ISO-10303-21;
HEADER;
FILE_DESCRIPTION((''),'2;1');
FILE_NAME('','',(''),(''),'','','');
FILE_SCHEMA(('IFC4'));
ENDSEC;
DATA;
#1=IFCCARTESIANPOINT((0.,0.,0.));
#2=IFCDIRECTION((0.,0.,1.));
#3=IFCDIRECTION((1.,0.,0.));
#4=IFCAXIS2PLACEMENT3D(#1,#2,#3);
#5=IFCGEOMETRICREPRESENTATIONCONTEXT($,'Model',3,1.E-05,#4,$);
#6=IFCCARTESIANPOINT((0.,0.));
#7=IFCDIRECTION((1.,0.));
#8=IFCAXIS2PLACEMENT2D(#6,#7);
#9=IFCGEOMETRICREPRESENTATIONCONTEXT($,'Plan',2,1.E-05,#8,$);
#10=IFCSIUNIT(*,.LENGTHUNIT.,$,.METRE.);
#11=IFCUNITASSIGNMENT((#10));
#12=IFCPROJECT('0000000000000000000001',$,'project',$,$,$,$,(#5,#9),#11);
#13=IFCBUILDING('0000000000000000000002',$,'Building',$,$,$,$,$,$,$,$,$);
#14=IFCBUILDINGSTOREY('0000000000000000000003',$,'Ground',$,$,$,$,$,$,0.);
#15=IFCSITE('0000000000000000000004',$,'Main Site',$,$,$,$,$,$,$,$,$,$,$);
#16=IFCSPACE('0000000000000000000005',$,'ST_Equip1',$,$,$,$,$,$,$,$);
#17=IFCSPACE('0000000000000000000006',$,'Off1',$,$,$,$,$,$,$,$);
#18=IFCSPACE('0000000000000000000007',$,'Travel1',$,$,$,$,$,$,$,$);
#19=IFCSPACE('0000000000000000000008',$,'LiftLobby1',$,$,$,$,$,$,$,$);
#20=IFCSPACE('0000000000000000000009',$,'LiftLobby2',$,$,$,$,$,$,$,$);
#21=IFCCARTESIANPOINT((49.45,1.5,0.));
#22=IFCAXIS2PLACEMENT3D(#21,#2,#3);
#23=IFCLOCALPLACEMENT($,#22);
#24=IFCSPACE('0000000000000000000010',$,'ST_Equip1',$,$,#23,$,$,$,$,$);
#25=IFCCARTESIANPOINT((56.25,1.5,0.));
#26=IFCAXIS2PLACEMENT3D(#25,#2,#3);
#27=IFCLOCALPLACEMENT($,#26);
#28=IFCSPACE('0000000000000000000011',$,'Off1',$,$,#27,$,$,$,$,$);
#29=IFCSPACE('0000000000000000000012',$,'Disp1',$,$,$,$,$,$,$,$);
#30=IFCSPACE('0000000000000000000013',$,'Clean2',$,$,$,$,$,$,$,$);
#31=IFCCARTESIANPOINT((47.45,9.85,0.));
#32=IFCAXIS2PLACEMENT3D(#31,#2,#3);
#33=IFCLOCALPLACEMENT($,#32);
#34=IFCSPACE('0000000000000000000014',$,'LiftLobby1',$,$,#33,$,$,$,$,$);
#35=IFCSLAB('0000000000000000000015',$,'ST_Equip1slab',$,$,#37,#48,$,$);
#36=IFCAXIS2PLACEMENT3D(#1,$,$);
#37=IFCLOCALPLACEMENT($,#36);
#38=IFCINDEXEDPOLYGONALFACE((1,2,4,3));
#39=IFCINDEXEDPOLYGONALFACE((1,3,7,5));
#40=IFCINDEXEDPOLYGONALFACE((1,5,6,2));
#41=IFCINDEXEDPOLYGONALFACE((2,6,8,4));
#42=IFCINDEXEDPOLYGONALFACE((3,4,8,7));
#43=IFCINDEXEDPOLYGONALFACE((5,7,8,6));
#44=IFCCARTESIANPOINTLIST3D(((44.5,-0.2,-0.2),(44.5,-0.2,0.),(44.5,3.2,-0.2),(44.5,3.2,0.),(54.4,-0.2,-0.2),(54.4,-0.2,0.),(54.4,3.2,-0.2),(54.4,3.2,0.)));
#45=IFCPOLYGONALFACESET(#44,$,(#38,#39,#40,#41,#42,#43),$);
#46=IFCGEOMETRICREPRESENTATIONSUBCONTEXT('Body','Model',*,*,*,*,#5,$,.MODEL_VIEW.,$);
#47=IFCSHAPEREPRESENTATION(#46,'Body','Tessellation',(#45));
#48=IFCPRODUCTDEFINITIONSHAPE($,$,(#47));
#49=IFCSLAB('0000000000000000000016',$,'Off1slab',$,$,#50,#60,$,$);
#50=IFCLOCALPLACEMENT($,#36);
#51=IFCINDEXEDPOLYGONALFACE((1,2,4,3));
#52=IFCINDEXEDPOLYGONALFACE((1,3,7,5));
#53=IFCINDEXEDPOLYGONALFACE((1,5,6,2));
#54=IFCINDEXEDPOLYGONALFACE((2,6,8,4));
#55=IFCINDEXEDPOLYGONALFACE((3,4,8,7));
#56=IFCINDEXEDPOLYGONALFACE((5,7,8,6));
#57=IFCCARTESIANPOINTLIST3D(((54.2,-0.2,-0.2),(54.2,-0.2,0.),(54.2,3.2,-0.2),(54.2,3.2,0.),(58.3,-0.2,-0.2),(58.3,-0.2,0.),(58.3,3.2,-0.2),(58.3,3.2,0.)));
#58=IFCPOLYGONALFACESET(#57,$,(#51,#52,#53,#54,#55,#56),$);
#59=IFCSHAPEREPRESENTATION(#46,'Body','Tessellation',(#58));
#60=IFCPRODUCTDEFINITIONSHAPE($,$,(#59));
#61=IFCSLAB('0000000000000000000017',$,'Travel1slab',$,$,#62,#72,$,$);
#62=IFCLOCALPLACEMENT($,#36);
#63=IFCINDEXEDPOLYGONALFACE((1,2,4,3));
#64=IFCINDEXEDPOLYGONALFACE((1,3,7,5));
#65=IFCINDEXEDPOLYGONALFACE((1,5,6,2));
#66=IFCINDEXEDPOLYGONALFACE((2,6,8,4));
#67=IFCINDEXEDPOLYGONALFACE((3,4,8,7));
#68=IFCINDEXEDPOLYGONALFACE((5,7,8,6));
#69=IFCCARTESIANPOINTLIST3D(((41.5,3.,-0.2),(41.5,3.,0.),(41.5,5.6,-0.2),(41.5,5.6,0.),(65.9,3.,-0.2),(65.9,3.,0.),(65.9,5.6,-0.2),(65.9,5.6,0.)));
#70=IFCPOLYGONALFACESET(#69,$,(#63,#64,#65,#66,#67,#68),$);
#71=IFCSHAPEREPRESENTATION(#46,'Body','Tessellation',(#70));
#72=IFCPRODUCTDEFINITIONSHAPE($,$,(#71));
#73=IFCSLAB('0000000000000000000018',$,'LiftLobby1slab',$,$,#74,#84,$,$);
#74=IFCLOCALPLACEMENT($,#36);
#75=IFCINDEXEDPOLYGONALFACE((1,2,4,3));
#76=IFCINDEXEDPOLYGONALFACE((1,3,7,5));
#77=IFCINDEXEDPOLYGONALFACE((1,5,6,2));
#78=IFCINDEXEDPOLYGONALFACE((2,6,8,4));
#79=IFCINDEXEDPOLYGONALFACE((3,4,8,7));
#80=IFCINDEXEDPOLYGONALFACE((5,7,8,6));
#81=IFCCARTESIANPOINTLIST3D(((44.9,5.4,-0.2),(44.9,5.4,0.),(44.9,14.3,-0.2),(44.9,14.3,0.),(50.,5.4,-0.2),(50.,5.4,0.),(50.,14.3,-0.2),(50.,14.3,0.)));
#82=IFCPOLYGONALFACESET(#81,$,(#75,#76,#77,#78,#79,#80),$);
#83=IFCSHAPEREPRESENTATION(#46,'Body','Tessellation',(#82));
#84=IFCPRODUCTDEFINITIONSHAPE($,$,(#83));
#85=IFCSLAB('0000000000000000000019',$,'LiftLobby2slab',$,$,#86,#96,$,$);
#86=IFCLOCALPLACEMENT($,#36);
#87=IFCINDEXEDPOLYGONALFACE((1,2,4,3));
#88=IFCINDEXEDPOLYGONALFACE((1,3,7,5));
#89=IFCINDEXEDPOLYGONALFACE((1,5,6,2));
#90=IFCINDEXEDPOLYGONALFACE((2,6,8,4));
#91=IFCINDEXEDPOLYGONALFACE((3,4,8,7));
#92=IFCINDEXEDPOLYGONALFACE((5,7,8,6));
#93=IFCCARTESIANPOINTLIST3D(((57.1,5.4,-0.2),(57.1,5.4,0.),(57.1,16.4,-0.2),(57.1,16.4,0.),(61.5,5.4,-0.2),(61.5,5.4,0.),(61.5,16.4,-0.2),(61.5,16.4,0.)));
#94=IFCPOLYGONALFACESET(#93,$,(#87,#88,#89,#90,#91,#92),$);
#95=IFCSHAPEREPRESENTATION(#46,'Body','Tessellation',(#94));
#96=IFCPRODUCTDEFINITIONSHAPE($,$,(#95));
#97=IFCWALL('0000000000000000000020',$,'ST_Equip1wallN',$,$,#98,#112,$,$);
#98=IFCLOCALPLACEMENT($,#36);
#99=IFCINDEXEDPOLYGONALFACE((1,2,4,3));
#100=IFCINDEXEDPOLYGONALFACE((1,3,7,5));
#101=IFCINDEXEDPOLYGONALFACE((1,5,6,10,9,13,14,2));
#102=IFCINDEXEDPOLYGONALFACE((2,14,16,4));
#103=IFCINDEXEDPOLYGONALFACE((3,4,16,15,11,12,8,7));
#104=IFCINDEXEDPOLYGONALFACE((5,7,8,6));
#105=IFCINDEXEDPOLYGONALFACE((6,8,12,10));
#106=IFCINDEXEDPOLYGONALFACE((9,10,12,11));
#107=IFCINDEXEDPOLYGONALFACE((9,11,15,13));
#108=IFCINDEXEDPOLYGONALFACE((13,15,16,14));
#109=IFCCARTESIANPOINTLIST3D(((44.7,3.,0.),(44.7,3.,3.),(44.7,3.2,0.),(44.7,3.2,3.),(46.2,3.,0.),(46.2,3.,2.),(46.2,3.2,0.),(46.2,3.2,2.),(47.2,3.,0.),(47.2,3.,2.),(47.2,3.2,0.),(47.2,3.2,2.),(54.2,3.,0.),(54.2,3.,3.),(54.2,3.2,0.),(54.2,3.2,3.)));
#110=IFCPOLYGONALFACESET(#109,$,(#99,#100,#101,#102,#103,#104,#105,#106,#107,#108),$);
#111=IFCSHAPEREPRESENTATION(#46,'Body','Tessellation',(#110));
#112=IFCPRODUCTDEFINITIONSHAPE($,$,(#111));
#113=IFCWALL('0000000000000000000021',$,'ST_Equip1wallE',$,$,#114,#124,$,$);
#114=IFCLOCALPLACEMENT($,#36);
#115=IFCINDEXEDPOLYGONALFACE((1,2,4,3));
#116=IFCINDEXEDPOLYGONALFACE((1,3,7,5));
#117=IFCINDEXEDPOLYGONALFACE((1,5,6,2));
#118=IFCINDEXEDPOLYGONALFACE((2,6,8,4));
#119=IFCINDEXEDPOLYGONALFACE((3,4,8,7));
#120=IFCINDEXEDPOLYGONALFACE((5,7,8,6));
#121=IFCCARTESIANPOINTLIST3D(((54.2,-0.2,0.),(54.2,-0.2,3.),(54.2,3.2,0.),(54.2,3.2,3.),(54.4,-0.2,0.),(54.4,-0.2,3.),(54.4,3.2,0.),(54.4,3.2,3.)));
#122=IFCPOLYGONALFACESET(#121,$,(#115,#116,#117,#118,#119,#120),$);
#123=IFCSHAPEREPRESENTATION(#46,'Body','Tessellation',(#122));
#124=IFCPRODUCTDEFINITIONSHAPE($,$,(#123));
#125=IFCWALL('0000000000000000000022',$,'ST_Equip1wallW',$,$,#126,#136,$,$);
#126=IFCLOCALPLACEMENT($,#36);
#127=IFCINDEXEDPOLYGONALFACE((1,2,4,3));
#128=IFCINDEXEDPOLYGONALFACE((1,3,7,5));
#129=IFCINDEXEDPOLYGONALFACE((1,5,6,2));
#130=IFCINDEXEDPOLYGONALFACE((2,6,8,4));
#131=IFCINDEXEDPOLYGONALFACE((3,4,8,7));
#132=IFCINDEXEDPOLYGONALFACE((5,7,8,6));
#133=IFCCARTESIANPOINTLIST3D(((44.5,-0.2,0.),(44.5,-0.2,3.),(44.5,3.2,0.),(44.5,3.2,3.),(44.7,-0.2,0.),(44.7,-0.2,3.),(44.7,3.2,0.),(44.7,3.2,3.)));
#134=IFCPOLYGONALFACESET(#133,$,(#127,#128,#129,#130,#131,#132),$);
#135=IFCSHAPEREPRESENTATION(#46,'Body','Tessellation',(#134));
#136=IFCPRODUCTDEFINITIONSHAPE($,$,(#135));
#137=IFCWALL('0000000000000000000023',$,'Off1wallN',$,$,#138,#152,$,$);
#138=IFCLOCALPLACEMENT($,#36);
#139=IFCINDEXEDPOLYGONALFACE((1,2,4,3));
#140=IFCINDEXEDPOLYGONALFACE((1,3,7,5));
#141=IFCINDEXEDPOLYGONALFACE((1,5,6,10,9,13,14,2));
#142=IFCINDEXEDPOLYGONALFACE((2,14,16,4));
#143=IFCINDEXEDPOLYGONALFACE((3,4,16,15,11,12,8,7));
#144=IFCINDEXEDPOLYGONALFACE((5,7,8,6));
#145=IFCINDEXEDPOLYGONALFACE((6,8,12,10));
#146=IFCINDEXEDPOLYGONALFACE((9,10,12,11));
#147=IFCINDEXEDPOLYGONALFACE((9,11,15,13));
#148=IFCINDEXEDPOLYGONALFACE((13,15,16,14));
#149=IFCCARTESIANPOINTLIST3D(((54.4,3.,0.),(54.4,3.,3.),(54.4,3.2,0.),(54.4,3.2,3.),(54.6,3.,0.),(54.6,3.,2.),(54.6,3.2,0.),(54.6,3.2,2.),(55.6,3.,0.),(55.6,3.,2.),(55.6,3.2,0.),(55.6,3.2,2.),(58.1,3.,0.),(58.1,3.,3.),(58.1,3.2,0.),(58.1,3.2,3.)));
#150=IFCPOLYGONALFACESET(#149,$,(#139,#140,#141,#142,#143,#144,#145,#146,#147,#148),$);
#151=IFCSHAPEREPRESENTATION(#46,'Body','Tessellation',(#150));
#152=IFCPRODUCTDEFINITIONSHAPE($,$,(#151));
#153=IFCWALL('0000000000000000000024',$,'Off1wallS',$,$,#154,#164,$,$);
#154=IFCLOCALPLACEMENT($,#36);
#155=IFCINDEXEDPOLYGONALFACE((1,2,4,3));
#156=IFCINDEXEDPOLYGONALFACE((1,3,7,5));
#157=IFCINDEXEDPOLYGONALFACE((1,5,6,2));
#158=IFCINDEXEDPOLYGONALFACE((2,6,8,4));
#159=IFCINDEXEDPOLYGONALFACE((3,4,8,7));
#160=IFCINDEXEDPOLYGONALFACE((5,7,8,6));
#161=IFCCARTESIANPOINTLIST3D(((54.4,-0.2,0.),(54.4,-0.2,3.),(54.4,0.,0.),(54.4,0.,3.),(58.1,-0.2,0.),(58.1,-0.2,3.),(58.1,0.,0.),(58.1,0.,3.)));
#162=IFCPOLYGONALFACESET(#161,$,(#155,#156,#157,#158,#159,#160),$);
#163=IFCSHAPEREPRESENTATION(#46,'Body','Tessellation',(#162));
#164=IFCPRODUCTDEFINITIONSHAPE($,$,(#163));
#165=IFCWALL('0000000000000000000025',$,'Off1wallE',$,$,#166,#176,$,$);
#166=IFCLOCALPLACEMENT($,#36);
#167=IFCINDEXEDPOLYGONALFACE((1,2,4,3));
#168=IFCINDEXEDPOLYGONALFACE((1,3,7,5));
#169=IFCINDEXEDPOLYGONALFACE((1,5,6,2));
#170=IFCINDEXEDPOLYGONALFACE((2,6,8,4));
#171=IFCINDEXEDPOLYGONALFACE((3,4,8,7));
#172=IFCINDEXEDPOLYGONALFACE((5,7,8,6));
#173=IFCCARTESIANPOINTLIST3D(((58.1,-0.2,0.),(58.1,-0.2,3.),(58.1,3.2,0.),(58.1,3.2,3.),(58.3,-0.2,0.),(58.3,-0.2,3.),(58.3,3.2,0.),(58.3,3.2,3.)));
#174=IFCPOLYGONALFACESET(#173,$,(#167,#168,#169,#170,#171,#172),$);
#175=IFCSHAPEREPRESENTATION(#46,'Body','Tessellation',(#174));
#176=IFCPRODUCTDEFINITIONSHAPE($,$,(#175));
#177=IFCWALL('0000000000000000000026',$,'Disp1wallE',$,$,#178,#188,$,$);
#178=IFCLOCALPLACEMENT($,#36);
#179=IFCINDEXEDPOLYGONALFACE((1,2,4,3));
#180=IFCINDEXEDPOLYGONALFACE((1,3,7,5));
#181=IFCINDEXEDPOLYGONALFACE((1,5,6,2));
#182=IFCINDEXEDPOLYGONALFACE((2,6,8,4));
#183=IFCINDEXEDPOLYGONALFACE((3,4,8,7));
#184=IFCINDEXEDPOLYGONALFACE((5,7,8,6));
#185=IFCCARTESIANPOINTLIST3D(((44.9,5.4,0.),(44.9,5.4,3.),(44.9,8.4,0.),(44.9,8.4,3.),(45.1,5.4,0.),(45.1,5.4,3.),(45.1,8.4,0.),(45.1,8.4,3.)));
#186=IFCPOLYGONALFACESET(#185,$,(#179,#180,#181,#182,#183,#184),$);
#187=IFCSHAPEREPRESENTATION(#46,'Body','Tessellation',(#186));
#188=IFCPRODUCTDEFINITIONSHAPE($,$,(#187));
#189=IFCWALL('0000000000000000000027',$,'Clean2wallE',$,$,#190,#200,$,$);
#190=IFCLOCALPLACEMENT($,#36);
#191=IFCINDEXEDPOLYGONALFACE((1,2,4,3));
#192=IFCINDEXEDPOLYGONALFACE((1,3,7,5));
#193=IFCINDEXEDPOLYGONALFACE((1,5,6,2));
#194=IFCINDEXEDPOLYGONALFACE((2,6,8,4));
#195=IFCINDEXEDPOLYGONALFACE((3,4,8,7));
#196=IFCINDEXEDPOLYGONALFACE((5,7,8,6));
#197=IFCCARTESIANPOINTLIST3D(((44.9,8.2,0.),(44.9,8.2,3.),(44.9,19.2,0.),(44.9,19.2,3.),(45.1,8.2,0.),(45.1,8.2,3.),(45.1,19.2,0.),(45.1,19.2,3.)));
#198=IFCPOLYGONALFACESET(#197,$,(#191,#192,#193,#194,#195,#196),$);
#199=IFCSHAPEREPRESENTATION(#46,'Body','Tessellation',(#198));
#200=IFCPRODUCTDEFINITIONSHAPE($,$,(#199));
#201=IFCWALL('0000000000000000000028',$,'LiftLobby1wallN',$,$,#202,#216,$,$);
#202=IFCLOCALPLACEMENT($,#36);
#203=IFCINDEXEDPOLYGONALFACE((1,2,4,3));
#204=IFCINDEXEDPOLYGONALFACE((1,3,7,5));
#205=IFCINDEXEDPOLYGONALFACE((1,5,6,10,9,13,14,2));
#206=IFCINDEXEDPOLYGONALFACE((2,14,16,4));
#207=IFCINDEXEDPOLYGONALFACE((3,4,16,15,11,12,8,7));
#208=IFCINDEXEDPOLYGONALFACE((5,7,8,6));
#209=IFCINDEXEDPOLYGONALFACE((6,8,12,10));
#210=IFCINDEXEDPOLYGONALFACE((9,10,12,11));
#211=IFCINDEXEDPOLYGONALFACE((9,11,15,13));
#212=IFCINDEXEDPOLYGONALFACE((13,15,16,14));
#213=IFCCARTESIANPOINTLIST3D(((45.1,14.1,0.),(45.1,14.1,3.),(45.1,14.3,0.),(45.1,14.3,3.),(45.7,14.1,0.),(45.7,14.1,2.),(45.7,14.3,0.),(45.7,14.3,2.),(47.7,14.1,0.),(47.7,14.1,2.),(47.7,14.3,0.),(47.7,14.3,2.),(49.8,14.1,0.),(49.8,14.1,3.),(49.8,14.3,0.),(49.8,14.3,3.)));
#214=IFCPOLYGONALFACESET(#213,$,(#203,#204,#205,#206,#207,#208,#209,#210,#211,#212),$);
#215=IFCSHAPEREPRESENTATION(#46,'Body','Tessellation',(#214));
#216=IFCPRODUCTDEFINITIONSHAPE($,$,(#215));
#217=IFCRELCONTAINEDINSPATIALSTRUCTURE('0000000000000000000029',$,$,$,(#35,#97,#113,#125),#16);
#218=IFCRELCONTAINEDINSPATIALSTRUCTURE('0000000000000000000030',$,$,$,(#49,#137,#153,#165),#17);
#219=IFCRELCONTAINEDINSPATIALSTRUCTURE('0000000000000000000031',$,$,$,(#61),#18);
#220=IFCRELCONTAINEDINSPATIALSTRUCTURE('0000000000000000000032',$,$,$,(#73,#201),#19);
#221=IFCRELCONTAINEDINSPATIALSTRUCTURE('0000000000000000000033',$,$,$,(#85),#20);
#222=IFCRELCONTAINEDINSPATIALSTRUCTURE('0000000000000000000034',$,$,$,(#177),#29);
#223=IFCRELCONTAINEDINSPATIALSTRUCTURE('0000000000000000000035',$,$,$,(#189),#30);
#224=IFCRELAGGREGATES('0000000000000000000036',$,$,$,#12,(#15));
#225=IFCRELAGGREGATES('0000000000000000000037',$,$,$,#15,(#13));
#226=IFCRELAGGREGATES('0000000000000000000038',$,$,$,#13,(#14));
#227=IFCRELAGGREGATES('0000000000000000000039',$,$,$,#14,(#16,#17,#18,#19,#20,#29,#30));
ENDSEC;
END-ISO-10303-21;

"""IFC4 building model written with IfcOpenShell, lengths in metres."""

from ifc_helpers import new_model, si_unit, frame, origin_with_axes, origin_2d_with_axis, place, context, subcontext, project, spatial, indexed_curve, rectangle, outline, extrude, element, save


model = new_model("IFC4")

# Units and contexts
model_context = context("Model", 3, precision=1e-05, world=origin_with_axes())
plan_context = context("Plan", 2, precision=1e-05, world=origin_2d_with_axis())
body_context = subcontext(model_context, "Body", "Model", "MODEL_VIEW")
ifc_project = project(units=[si_unit("LENGTHUNIT", "METRE")], contexts=[model_context, plan_context])

# Site, building, storey, space
site = spatial("IfcSite", under=ifc_project, Name="Main Site")
building = spatial("IfcBuilding", under=site, Name="Building")
storey = spatial("IfcBuildingStorey", under=building, Name="Ground", Elevation=0.0)
space_1 = spatial("IfcSpace", under=storey, Name="ST_Equip1")

# Slab
slab_1_placement = place(None, frame((49.45, 1.5, -0.2), z_axis=(0.0, 0.0, 1.0), x_axis=(1.0, 0.0, 0.0)))
element("IfcSlab", 1, at=slab_1_placement, inside=space_1, Name="ST_Equip1slab", context=body_context, shape_type="SweptSolid", body=[
    extrude(rectangle(XDim=9.9, YDim=3.4), origin_with_axes(), (0.0, 0.0, 1.0), 0.2),
])

# Shared definitions
space_2 = spatial("IfcSpace", under=storey, Name="Off1")

# Slab
slab_2_placement = place(None, frame((56.25, 1.5, -0.2), z_axis=(0.0, 0.0, 1.0), x_axis=(1.0, 0.0, 0.0)))
element("IfcSlab", 2, at=slab_2_placement, inside=space_2, Name="Off1slab", context=body_context, shape_type="SweptSolid", body=[
    extrude(rectangle(XDim=4.1, YDim=3.4), origin_with_axes(), (0.0, 0.0, 1.0), 0.2),
])

# Shared definitions
space_3 = spatial("IfcSpace", under=storey, Name="Travel1")

# Slab
slab_3_placement = place(None, frame((53.7, 4.3, -0.2), z_axis=(0.0, 0.0, 1.0), x_axis=(1.0, 0.0, 0.0)))
element("IfcSlab", 3, at=slab_3_placement, inside=space_3, Name="Travel1slab", context=body_context, shape_type="SweptSolid", body=[
    extrude(rectangle(XDim=24.4, YDim=2.6), origin_with_axes(), (0.0, 0.0, 1.0), 0.2),
])

# Shared definitions
space_4 = spatial("IfcSpace", under=storey, Name="LiftLobby1")

# Slab
slab_4_placement = place(None, frame((47.45, 9.85, -0.2), z_axis=(0.0, 0.0, 1.0), x_axis=(1.0, 0.0, 0.0)))
element("IfcSlab", 4, at=slab_4_placement, inside=space_4, Name="LiftLobby1slab", context=body_context, shape_type="SweptSolid", body=[
    extrude(rectangle(XDim=5.1, YDim=8.9), origin_with_axes(), (0.0, 0.0, 1.0), 0.2),
])

# Shared definitions
space_5 = spatial("IfcSpace", under=storey, Name="LiftLobby2")

# Slab
slab_5_placement = place(None, frame((59.3, 10.9, -0.2), z_axis=(0.0, 0.0, 1.0), x_axis=(1.0, 0.0, 0.0)))
element("IfcSlab", 5, at=slab_5_placement, inside=space_5, Name="LiftLobby2slab", context=body_context, shape_type="SweptSolid", body=[
    extrude(rectangle(XDim=4.4, YDim=11.0), origin_with_axes(), (0.0, 0.0, 1.0), 0.2),
])

# Wall
wall_1_placement = place(None, frame((44.7, 3.0, 0.0), z_axis=(0.0, 0.0, 1.0), x_axis=(1.0, 0.0, 0.0)))
wall_1 = element("IfcWall", 6, at=wall_1_placement, inside=space_1, Name="ST_Equip1wallN", context=body_context, shape_type="SweptSolid", body=[
    extrude(outline(indexed_curve([(0.0, 0.0), (0.0, 0.2), (9.5, 0.2), (9.5, 0.0), (0.0, 0.0)], self_intersect=False)), origin_with_axes(), (0.0, 0.0, 1.0), 3.0),
])

# Shared definitions
space_6_placement = place(None, frame((49.45, 1.5, 0.0), z_axis=(0.0, 0.0, 1.0), x_axis=(1.0, 0.0, 0.0)))
space_6 = spatial("IfcSpace", at=space_6_placement, Name="ST_Equip1")

# Opening
opening_1_placement = place(wall_1_placement, frame((1.5, 0.0, 0.0), z_axis=(0.0, 0.0, 1.0), x_axis=(1.0, 0.0, 0.0)))
element("IfcOpeningElement", 7, at=opening_1_placement, inside=space_6, cuts=wall_1, context=body_context, shape_type="SweptSolid", body=[
    extrude(outline(indexed_curve([(0.0, 0.0), (0.0, 0.4), (1.0, 0.4), (1.0, 0.0), (0.0, 0.0)], self_intersect=False)), origin_with_axes(), (0.0, 0.0, 1.0), 2.0),
])

# Walls
for number, where, z_axis, x_axis, name in (
    (8, (54.4, -0.2, 0.0), (0.0, 0.0, 1.0), (0.0, 1.0, 0.0), "ST_Equip1wallE"),
    (9, (44.7, -0.2, 0.0), (0.0, 0.0, 1.0), (0.0, 1.0, 0.0), "ST_Equip1wallW"),
):
    element("IfcWall", number, at=place(None, frame(where, z_axis=z_axis, x_axis=x_axis)), inside=space_1, Name=name, context=body_context, shape_type="SweptSolid", body=[
        extrude(outline(indexed_curve([(0.0, 0.0), (0.0, 0.2), (3.4, 0.2), (3.4, 0.0), (0.0, 0.0)], self_intersect=False)), origin_with_axes(), (0.0, 0.0, 1.0), 3.0),
    ])

# Wall
wall_2_placement = place(None, frame((54.4, 3.0, 0.0), z_axis=(0.0, 0.0, 1.0), x_axis=(1.0, 0.0, 0.0)))
wall_2 = element("IfcWall", 10, at=wall_2_placement, inside=space_2, Name="Off1wallN", context=body_context, shape_type="SweptSolid", body=[
    extrude(outline(indexed_curve([(0.0, 0.0), (0.0, 0.2), (3.7, 0.2), (3.7, 0.0), (0.0, 0.0)], self_intersect=False)), origin_with_axes(), (0.0, 0.0, 1.0), 3.0),
])

# Shared definitions
space_7_placement = place(None, frame((56.25, 1.5, 0.0), z_axis=(0.0, 0.0, 1.0), x_axis=(1.0, 0.0, 0.0)))
space_7 = spatial("IfcSpace", at=space_7_placement, Name="Off1")

# Opening
opening_2_placement = place(wall_2_placement, frame((0.2, 0.0, 0.0), z_axis=(0.0, 0.0, 1.0), x_axis=(1.0, 0.0, 0.0)))
element("IfcOpeningElement", 11, at=opening_2_placement, inside=space_7, cuts=wall_2, context=body_context, shape_type="SweptSolid", body=[
    extrude(outline(indexed_curve([(0.0, 0.0), (0.0, 0.4), (1.0, 0.4), (1.0, 0.0), (0.0, 0.0)], self_intersect=False)), origin_with_axes(), (0.0, 0.0, 1.0), 2.0),
])

# Walls
wall_3_placement = place(None, frame((54.4, -0.2, 0.0), z_axis=(0.0, 0.0, 1.0), x_axis=(1.0, 0.0, 0.0)))
element("IfcWall", 12, at=wall_3_placement, inside=space_2, Name="Off1wallS", context=body_context, shape_type="SweptSolid", body=[
    extrude(outline(indexed_curve([(0.0, 0.0), (0.0, 0.2), (3.7, 0.2), (3.7, 0.0), (0.0, 0.0)], self_intersect=False)), origin_with_axes(), (0.0, 0.0, 1.0), 3.0),
])
for number, where, z_axis, x_axis, name in (
    (13, (58.3, -0.2, 0.0), (0.0, 0.0, 1.0), (0.0, 1.0, 0.0), "Off1wallE"),
):
    element("IfcWall", number, at=place(None, frame(where, z_axis=z_axis, x_axis=x_axis)), inside=space_2, Name=name, context=body_context, shape_type="SweptSolid", body=[
        extrude(outline(indexed_curve([(0.0, 0.0), (0.0, 0.2), (3.4, 0.2), (3.4, 0.0), (0.0, 0.0)], self_intersect=False)), origin_with_axes(), (0.0, 0.0, 1.0), 3.0),
    ])

# Shared definitions
space_8 = spatial("IfcSpace", under=storey, Name="Disp1")

# Wall
wall_4_placement = place(None, frame((45.1, 5.4, 0.0), z_axis=(0.0, 0.0, 1.0), x_axis=(0.0, 1.0, 0.0)))
element("IfcWall", 14, at=wall_4_placement, inside=space_8, Name="Disp1wallE", context=body_context, shape_type="SweptSolid", body=[
    extrude(outline(indexed_curve([(0.0, 0.0), (0.0, 0.2), (3.0, 0.2), (3.0, 0.0), (0.0, 0.0)], self_intersect=False)), origin_with_axes(), (0.0, 0.0, 1.0), 3.0),
])

# Shared definitions
space_9 = spatial("IfcSpace", under=storey, Name="Clean2")

# Walls
wall_5_placement = place(None, frame((45.1, 8.2, 0.0), z_axis=(0.0, 0.0, 1.0), x_axis=(0.0, 1.0, 0.0)))
element("IfcWall", 15, at=wall_5_placement, inside=space_9, Name="Clean2wallE", context=body_context, shape_type="SweptSolid", body=[
    extrude(outline(indexed_curve([(0.0, 0.0), (0.0, 0.2), (11.0, 0.2), (11.0, 0.0), (0.0, 0.0)], self_intersect=False)), origin_with_axes(), (0.0, 0.0, 1.0), 3.0),
])
wall_6_placement = place(None, frame((45.1, 14.1, 0.0), z_axis=(0.0, 0.0, 1.0), x_axis=(1.0, 0.0, 0.0)))
wall_6 = element("IfcWall", 16, at=wall_6_placement, inside=space_4, Name="LiftLobby1wallN", context=body_context, shape_type="SweptSolid", body=[
    extrude(outline(indexed_curve([(0.0, 0.0), (0.0, 0.2), (4.7, 0.2), (4.7, 0.0), (0.0, 0.0)], self_intersect=False)), origin_with_axes(), (0.0, 0.0, 1.0), 3.0),
])

# Shared definitions
space_10_placement = place(None, frame((47.45, 9.85, 0.0), z_axis=(0.0, 0.0, 1.0), x_axis=(1.0, 0.0, 0.0)))
space_10 = spatial("IfcSpace", at=space_10_placement, Name="LiftLobby1")

# Opening
opening_3_placement = place(wall_6_placement, frame((0.6, 0.0, 0.0), z_axis=(0.0, 0.0, 1.0), x_axis=(1.0, 0.0, 0.0)))
element("IfcOpeningElement", 17, at=opening_3_placement, inside=space_10, cuts=wall_6, context=body_context, shape_type="SweptSolid", body=[
    extrude(outline(indexed_curve([(0.0, 0.0), (0.0, 0.4), (2.0, 0.4), (2.0, 0.0), (0.0, 0.0)], self_intersect=False)), origin_with_axes(), (0.0, 0.0, 1.0), 2.0),
])

save(model, "model.ifc")
